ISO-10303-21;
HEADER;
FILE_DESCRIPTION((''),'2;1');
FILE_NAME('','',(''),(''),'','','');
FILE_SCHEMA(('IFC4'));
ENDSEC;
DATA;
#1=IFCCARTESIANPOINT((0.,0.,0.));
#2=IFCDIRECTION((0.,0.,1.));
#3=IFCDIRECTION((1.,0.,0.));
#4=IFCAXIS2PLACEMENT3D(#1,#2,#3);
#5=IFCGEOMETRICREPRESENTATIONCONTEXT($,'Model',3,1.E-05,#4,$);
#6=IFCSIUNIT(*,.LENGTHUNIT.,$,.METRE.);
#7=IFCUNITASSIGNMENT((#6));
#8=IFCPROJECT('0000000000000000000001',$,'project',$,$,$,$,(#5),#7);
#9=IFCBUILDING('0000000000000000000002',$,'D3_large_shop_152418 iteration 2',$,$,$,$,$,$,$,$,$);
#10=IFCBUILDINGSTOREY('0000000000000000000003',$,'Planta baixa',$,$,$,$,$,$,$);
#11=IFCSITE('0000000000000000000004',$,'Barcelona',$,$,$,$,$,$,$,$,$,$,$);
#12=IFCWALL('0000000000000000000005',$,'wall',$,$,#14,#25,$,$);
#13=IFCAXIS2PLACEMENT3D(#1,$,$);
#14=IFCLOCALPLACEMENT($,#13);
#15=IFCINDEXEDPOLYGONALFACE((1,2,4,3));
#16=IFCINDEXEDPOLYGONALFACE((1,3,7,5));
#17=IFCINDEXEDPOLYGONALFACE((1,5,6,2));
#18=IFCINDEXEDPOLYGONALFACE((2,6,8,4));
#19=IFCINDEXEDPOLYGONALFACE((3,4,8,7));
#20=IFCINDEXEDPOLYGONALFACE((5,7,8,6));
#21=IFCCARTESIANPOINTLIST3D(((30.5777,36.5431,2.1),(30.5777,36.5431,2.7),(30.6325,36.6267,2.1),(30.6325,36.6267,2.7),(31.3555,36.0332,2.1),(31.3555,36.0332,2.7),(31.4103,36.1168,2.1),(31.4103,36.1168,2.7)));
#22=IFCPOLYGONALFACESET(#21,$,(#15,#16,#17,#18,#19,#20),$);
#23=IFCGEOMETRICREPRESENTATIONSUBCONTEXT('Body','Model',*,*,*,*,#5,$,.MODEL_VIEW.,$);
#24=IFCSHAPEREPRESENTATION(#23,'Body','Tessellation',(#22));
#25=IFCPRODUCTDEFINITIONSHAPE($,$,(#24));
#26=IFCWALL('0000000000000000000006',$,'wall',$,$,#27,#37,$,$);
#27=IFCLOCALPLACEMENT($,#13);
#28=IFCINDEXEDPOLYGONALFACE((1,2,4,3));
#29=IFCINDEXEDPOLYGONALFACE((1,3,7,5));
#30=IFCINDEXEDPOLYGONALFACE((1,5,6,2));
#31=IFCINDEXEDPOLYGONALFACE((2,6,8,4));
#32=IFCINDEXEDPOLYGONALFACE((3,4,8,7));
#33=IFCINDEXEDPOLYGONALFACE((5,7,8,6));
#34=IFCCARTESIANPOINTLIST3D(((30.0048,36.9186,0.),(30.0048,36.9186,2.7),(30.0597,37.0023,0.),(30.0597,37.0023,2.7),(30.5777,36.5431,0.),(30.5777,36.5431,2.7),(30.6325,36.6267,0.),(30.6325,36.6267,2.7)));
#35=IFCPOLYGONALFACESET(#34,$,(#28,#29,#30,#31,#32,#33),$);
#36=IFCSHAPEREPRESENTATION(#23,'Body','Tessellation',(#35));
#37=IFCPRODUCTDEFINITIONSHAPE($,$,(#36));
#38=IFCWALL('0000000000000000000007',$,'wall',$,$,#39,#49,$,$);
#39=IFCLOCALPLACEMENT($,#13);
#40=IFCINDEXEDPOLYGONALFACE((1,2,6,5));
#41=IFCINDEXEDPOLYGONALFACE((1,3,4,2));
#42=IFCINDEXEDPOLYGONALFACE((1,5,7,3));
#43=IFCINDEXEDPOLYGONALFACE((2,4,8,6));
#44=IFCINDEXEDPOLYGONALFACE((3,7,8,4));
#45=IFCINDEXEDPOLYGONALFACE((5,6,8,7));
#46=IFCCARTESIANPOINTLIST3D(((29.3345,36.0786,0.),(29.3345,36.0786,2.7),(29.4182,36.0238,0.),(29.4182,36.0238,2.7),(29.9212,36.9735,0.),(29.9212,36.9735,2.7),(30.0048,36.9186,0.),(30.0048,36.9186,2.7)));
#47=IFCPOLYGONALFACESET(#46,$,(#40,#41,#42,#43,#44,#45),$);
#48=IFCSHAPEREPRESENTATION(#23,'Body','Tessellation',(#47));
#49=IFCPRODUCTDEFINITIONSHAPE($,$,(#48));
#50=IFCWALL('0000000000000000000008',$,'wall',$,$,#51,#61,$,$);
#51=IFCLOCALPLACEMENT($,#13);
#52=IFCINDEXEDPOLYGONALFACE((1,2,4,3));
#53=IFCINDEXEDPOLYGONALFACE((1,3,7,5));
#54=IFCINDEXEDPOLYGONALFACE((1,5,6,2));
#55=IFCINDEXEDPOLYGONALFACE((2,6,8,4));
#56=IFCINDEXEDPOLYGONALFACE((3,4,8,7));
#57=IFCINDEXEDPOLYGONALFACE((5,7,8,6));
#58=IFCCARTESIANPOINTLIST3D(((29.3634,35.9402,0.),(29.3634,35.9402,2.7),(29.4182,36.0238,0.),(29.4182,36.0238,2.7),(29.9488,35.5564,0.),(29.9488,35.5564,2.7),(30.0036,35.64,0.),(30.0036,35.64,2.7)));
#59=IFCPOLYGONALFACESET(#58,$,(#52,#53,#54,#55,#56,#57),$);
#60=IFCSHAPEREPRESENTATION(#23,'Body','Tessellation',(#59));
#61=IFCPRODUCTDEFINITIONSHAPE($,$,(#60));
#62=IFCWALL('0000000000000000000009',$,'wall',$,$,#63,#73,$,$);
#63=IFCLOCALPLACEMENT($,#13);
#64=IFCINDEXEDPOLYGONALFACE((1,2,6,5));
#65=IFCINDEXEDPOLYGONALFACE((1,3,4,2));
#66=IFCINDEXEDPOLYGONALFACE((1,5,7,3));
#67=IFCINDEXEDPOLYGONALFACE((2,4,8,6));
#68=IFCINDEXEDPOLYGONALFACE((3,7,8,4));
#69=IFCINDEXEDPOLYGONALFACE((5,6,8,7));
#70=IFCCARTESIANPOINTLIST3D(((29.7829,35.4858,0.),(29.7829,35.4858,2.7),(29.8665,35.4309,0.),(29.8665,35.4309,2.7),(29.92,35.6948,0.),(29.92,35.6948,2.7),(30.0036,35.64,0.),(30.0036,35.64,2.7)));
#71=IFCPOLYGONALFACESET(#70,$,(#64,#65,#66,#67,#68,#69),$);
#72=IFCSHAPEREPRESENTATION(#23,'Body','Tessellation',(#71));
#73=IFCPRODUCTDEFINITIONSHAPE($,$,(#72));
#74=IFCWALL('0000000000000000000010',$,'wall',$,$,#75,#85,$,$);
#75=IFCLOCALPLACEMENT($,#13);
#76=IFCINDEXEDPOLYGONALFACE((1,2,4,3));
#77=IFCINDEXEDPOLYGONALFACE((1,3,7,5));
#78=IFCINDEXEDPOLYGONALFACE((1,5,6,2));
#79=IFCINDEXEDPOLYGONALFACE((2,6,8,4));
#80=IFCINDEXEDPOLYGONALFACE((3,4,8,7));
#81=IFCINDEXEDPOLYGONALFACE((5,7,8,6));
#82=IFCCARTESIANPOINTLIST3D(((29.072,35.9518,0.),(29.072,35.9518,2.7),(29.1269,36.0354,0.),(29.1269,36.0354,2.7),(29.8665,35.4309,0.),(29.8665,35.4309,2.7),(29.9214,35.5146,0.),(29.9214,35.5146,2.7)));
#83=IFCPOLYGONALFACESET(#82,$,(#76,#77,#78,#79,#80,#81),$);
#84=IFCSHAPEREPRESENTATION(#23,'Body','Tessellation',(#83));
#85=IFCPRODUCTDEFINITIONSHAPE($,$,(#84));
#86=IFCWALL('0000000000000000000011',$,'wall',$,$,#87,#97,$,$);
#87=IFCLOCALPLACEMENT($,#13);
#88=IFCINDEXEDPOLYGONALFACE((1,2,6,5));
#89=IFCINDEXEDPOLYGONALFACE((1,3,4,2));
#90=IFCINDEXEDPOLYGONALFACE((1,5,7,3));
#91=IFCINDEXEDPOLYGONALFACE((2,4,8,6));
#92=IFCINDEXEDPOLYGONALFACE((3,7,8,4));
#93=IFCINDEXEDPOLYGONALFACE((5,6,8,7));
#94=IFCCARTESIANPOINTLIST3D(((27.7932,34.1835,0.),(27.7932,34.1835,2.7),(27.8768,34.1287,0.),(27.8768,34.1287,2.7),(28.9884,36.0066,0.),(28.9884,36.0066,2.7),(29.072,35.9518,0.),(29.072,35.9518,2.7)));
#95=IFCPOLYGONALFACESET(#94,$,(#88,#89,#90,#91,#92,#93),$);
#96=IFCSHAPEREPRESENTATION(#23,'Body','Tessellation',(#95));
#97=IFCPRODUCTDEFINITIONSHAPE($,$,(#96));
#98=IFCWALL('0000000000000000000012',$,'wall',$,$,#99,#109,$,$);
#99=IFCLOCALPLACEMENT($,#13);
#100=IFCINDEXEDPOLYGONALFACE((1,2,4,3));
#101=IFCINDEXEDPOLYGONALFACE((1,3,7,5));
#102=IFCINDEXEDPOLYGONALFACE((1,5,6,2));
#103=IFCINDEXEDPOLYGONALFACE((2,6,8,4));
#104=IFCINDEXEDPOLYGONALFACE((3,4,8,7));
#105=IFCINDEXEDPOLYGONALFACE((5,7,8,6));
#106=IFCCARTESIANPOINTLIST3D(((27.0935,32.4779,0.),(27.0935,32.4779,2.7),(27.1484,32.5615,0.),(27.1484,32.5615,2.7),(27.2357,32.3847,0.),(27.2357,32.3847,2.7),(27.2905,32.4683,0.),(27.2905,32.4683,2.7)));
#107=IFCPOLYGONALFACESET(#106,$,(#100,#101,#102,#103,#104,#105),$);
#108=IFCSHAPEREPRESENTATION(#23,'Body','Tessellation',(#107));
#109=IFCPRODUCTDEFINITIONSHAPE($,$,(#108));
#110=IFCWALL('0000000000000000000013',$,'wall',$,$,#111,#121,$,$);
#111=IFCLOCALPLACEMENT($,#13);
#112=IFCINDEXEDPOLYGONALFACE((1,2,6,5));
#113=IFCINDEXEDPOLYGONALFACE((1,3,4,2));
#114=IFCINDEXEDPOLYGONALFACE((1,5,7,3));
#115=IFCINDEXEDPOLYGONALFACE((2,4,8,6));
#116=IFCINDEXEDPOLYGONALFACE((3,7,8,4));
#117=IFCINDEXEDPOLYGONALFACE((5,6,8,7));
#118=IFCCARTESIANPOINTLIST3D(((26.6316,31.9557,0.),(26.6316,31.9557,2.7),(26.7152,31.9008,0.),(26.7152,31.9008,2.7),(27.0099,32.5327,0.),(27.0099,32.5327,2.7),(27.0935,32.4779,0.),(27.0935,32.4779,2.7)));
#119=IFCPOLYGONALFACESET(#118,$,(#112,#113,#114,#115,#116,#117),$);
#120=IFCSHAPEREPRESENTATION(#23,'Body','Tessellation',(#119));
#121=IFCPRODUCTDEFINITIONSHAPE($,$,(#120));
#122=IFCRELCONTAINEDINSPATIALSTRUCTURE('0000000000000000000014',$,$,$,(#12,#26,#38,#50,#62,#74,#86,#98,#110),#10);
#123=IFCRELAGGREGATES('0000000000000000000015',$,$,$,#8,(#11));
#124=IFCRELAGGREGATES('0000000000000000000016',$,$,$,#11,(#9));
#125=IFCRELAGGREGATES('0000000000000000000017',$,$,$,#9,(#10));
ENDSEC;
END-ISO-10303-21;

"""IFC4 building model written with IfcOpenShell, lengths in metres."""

from ifc_helpers import new_model, si_unit, frame, origin, origin_with_axes, place, context, subcontext, project, spatial, polyline, outline, extrude, element, save


model = new_model("IFC4")

# Units and contexts
model_context = context("Model", 3, precision=1e-05, world=origin_with_axes())
body_context = subcontext(model_context, "Body", "Model", "MODEL_VIEW")
ifc_project = project(units=[si_unit("LENGTHUNIT", "METRE")], contexts=[model_context])

# Site, building, storey
site = spatial("IfcSite", under=ifc_project, Name="Barcelona")
building = spatial("IfcBuilding", under=site, Name="D3_large_shop_152418 iteration 2")
storey = spatial("IfcBuildingStorey", under=building, Name="Planta baixa")

# Walls
wall_1_placement = place(None, origin_with_axes())
element("IfcWall", 1, at=wall_1_placement, inside=storey, Name="wall", context=body_context, shape_type="SweptSolid", body=[
    extrude(outline(polyline([(31.3555, 36.0332), (30.5777, 36.5431), (30.6325, 36.6267), (31.4103, 36.1168), (31.3555, 36.0332)])), frame((0.0, 0.0, 2.1)), (0.0, 0.0, 1.0), 0.6),
])
wall_2_placement = place(None, origin_with_axes())
element("IfcWall", 2, at=wall_2_placement, inside=storey, Name="wall", context=body_context, shape_type="SweptSolid", body=[
    extrude(outline(polyline([(30.5777, 36.5431), (30.0048, 36.9186), (30.0597, 37.0023), (30.6325, 36.6267), (30.5777, 36.5431)])), origin(), (0.0, 0.0, 1.0), 2.7),
])
wall_3_placement = place(None, origin_with_axes())
element("IfcWall", 3, at=wall_3_placement, inside=storey, Name="wall", context=body_context, shape_type="SweptSolid", body=[
    extrude(outline(polyline([(30.0048, 36.9186), (29.4182, 36.0238), (29.3345, 36.0786), (29.9212, 36.9735), (30.0048, 36.9186)])), origin(), (0.0, 0.0, 1.0), 2.7),
])
wall_4_placement = place(None, origin_with_axes())
element("IfcWall", 4, at=wall_4_placement, inside=storey, Name="wall", context=body_context, shape_type="SweptSolid", body=[
    extrude(outline(polyline([(29.4182, 36.0238), (30.0036, 35.64), (29.9488, 35.5564), (29.3634, 35.9402), (29.4182, 36.0238)])), origin(), (0.0, 0.0, 1.0), 2.7),
])
wall_5_placement = place(None, origin_with_axes())
element("IfcWall", 5, at=wall_5_placement, inside=storey, Name="wall", context=body_context, shape_type="SweptSolid", body=[
    extrude(outline(polyline([(30.0036, 35.64), (29.8665, 35.4309), (29.7829, 35.4858), (29.92, 35.6948), (30.0036, 35.64)])), origin(), (0.0, 0.0, 1.0), 2.7),
])
wall_6_placement = place(None, origin_with_axes())
element("IfcWall", 6, at=wall_6_placement, inside=storey, Name="wall", context=body_context, shape_type="SweptSolid", body=[
    extrude(outline(polyline([(29.8665, 35.4309), (29.072, 35.9518), (29.1269, 36.0354), (29.9214, 35.5146), (29.8665, 35.4309)])), origin(), (0.0, 0.0, 1.0), 2.7),
])
wall_7_placement = place(None, origin_with_axes())
element("IfcWall", 7, at=wall_7_placement, inside=storey, Name="wall", context=body_context, shape_type="SweptSolid", body=[
    extrude(outline(polyline([(29.072, 35.9518), (27.8768, 34.1287), (27.7932, 34.1835), (28.9884, 36.0066), (29.072, 35.9518)])), origin(), (0.0, 0.0, 1.0), 2.7),
])
wall_8_placement = place(None, origin_with_axes())
element("IfcWall", 8, at=wall_8_placement, inside=storey, Name="wall", context=body_context, shape_type="SweptSolid", body=[
    extrude(outline(polyline([(27.2357, 32.3847), (27.0935, 32.4779), (27.1484, 32.5615), (27.2905, 32.4683), (27.2357, 32.3847)])), origin(), (0.0, 0.0, 1.0), 2.7),
])
wall_9_placement = place(None, origin_with_axes())
element("IfcWall", 9, at=wall_9_placement, inside=storey, Name="wall", context=body_context, shape_type="SweptSolid", body=[
    extrude(outline(polyline([(27.0935, 32.4779), (26.7152, 31.9008), (26.6316, 31.9557), (27.0099, 32.5327), (27.0935, 32.4779)])), origin(), (0.0, 0.0, 1.0), 2.7),
])

save(model, "model.ifc")
